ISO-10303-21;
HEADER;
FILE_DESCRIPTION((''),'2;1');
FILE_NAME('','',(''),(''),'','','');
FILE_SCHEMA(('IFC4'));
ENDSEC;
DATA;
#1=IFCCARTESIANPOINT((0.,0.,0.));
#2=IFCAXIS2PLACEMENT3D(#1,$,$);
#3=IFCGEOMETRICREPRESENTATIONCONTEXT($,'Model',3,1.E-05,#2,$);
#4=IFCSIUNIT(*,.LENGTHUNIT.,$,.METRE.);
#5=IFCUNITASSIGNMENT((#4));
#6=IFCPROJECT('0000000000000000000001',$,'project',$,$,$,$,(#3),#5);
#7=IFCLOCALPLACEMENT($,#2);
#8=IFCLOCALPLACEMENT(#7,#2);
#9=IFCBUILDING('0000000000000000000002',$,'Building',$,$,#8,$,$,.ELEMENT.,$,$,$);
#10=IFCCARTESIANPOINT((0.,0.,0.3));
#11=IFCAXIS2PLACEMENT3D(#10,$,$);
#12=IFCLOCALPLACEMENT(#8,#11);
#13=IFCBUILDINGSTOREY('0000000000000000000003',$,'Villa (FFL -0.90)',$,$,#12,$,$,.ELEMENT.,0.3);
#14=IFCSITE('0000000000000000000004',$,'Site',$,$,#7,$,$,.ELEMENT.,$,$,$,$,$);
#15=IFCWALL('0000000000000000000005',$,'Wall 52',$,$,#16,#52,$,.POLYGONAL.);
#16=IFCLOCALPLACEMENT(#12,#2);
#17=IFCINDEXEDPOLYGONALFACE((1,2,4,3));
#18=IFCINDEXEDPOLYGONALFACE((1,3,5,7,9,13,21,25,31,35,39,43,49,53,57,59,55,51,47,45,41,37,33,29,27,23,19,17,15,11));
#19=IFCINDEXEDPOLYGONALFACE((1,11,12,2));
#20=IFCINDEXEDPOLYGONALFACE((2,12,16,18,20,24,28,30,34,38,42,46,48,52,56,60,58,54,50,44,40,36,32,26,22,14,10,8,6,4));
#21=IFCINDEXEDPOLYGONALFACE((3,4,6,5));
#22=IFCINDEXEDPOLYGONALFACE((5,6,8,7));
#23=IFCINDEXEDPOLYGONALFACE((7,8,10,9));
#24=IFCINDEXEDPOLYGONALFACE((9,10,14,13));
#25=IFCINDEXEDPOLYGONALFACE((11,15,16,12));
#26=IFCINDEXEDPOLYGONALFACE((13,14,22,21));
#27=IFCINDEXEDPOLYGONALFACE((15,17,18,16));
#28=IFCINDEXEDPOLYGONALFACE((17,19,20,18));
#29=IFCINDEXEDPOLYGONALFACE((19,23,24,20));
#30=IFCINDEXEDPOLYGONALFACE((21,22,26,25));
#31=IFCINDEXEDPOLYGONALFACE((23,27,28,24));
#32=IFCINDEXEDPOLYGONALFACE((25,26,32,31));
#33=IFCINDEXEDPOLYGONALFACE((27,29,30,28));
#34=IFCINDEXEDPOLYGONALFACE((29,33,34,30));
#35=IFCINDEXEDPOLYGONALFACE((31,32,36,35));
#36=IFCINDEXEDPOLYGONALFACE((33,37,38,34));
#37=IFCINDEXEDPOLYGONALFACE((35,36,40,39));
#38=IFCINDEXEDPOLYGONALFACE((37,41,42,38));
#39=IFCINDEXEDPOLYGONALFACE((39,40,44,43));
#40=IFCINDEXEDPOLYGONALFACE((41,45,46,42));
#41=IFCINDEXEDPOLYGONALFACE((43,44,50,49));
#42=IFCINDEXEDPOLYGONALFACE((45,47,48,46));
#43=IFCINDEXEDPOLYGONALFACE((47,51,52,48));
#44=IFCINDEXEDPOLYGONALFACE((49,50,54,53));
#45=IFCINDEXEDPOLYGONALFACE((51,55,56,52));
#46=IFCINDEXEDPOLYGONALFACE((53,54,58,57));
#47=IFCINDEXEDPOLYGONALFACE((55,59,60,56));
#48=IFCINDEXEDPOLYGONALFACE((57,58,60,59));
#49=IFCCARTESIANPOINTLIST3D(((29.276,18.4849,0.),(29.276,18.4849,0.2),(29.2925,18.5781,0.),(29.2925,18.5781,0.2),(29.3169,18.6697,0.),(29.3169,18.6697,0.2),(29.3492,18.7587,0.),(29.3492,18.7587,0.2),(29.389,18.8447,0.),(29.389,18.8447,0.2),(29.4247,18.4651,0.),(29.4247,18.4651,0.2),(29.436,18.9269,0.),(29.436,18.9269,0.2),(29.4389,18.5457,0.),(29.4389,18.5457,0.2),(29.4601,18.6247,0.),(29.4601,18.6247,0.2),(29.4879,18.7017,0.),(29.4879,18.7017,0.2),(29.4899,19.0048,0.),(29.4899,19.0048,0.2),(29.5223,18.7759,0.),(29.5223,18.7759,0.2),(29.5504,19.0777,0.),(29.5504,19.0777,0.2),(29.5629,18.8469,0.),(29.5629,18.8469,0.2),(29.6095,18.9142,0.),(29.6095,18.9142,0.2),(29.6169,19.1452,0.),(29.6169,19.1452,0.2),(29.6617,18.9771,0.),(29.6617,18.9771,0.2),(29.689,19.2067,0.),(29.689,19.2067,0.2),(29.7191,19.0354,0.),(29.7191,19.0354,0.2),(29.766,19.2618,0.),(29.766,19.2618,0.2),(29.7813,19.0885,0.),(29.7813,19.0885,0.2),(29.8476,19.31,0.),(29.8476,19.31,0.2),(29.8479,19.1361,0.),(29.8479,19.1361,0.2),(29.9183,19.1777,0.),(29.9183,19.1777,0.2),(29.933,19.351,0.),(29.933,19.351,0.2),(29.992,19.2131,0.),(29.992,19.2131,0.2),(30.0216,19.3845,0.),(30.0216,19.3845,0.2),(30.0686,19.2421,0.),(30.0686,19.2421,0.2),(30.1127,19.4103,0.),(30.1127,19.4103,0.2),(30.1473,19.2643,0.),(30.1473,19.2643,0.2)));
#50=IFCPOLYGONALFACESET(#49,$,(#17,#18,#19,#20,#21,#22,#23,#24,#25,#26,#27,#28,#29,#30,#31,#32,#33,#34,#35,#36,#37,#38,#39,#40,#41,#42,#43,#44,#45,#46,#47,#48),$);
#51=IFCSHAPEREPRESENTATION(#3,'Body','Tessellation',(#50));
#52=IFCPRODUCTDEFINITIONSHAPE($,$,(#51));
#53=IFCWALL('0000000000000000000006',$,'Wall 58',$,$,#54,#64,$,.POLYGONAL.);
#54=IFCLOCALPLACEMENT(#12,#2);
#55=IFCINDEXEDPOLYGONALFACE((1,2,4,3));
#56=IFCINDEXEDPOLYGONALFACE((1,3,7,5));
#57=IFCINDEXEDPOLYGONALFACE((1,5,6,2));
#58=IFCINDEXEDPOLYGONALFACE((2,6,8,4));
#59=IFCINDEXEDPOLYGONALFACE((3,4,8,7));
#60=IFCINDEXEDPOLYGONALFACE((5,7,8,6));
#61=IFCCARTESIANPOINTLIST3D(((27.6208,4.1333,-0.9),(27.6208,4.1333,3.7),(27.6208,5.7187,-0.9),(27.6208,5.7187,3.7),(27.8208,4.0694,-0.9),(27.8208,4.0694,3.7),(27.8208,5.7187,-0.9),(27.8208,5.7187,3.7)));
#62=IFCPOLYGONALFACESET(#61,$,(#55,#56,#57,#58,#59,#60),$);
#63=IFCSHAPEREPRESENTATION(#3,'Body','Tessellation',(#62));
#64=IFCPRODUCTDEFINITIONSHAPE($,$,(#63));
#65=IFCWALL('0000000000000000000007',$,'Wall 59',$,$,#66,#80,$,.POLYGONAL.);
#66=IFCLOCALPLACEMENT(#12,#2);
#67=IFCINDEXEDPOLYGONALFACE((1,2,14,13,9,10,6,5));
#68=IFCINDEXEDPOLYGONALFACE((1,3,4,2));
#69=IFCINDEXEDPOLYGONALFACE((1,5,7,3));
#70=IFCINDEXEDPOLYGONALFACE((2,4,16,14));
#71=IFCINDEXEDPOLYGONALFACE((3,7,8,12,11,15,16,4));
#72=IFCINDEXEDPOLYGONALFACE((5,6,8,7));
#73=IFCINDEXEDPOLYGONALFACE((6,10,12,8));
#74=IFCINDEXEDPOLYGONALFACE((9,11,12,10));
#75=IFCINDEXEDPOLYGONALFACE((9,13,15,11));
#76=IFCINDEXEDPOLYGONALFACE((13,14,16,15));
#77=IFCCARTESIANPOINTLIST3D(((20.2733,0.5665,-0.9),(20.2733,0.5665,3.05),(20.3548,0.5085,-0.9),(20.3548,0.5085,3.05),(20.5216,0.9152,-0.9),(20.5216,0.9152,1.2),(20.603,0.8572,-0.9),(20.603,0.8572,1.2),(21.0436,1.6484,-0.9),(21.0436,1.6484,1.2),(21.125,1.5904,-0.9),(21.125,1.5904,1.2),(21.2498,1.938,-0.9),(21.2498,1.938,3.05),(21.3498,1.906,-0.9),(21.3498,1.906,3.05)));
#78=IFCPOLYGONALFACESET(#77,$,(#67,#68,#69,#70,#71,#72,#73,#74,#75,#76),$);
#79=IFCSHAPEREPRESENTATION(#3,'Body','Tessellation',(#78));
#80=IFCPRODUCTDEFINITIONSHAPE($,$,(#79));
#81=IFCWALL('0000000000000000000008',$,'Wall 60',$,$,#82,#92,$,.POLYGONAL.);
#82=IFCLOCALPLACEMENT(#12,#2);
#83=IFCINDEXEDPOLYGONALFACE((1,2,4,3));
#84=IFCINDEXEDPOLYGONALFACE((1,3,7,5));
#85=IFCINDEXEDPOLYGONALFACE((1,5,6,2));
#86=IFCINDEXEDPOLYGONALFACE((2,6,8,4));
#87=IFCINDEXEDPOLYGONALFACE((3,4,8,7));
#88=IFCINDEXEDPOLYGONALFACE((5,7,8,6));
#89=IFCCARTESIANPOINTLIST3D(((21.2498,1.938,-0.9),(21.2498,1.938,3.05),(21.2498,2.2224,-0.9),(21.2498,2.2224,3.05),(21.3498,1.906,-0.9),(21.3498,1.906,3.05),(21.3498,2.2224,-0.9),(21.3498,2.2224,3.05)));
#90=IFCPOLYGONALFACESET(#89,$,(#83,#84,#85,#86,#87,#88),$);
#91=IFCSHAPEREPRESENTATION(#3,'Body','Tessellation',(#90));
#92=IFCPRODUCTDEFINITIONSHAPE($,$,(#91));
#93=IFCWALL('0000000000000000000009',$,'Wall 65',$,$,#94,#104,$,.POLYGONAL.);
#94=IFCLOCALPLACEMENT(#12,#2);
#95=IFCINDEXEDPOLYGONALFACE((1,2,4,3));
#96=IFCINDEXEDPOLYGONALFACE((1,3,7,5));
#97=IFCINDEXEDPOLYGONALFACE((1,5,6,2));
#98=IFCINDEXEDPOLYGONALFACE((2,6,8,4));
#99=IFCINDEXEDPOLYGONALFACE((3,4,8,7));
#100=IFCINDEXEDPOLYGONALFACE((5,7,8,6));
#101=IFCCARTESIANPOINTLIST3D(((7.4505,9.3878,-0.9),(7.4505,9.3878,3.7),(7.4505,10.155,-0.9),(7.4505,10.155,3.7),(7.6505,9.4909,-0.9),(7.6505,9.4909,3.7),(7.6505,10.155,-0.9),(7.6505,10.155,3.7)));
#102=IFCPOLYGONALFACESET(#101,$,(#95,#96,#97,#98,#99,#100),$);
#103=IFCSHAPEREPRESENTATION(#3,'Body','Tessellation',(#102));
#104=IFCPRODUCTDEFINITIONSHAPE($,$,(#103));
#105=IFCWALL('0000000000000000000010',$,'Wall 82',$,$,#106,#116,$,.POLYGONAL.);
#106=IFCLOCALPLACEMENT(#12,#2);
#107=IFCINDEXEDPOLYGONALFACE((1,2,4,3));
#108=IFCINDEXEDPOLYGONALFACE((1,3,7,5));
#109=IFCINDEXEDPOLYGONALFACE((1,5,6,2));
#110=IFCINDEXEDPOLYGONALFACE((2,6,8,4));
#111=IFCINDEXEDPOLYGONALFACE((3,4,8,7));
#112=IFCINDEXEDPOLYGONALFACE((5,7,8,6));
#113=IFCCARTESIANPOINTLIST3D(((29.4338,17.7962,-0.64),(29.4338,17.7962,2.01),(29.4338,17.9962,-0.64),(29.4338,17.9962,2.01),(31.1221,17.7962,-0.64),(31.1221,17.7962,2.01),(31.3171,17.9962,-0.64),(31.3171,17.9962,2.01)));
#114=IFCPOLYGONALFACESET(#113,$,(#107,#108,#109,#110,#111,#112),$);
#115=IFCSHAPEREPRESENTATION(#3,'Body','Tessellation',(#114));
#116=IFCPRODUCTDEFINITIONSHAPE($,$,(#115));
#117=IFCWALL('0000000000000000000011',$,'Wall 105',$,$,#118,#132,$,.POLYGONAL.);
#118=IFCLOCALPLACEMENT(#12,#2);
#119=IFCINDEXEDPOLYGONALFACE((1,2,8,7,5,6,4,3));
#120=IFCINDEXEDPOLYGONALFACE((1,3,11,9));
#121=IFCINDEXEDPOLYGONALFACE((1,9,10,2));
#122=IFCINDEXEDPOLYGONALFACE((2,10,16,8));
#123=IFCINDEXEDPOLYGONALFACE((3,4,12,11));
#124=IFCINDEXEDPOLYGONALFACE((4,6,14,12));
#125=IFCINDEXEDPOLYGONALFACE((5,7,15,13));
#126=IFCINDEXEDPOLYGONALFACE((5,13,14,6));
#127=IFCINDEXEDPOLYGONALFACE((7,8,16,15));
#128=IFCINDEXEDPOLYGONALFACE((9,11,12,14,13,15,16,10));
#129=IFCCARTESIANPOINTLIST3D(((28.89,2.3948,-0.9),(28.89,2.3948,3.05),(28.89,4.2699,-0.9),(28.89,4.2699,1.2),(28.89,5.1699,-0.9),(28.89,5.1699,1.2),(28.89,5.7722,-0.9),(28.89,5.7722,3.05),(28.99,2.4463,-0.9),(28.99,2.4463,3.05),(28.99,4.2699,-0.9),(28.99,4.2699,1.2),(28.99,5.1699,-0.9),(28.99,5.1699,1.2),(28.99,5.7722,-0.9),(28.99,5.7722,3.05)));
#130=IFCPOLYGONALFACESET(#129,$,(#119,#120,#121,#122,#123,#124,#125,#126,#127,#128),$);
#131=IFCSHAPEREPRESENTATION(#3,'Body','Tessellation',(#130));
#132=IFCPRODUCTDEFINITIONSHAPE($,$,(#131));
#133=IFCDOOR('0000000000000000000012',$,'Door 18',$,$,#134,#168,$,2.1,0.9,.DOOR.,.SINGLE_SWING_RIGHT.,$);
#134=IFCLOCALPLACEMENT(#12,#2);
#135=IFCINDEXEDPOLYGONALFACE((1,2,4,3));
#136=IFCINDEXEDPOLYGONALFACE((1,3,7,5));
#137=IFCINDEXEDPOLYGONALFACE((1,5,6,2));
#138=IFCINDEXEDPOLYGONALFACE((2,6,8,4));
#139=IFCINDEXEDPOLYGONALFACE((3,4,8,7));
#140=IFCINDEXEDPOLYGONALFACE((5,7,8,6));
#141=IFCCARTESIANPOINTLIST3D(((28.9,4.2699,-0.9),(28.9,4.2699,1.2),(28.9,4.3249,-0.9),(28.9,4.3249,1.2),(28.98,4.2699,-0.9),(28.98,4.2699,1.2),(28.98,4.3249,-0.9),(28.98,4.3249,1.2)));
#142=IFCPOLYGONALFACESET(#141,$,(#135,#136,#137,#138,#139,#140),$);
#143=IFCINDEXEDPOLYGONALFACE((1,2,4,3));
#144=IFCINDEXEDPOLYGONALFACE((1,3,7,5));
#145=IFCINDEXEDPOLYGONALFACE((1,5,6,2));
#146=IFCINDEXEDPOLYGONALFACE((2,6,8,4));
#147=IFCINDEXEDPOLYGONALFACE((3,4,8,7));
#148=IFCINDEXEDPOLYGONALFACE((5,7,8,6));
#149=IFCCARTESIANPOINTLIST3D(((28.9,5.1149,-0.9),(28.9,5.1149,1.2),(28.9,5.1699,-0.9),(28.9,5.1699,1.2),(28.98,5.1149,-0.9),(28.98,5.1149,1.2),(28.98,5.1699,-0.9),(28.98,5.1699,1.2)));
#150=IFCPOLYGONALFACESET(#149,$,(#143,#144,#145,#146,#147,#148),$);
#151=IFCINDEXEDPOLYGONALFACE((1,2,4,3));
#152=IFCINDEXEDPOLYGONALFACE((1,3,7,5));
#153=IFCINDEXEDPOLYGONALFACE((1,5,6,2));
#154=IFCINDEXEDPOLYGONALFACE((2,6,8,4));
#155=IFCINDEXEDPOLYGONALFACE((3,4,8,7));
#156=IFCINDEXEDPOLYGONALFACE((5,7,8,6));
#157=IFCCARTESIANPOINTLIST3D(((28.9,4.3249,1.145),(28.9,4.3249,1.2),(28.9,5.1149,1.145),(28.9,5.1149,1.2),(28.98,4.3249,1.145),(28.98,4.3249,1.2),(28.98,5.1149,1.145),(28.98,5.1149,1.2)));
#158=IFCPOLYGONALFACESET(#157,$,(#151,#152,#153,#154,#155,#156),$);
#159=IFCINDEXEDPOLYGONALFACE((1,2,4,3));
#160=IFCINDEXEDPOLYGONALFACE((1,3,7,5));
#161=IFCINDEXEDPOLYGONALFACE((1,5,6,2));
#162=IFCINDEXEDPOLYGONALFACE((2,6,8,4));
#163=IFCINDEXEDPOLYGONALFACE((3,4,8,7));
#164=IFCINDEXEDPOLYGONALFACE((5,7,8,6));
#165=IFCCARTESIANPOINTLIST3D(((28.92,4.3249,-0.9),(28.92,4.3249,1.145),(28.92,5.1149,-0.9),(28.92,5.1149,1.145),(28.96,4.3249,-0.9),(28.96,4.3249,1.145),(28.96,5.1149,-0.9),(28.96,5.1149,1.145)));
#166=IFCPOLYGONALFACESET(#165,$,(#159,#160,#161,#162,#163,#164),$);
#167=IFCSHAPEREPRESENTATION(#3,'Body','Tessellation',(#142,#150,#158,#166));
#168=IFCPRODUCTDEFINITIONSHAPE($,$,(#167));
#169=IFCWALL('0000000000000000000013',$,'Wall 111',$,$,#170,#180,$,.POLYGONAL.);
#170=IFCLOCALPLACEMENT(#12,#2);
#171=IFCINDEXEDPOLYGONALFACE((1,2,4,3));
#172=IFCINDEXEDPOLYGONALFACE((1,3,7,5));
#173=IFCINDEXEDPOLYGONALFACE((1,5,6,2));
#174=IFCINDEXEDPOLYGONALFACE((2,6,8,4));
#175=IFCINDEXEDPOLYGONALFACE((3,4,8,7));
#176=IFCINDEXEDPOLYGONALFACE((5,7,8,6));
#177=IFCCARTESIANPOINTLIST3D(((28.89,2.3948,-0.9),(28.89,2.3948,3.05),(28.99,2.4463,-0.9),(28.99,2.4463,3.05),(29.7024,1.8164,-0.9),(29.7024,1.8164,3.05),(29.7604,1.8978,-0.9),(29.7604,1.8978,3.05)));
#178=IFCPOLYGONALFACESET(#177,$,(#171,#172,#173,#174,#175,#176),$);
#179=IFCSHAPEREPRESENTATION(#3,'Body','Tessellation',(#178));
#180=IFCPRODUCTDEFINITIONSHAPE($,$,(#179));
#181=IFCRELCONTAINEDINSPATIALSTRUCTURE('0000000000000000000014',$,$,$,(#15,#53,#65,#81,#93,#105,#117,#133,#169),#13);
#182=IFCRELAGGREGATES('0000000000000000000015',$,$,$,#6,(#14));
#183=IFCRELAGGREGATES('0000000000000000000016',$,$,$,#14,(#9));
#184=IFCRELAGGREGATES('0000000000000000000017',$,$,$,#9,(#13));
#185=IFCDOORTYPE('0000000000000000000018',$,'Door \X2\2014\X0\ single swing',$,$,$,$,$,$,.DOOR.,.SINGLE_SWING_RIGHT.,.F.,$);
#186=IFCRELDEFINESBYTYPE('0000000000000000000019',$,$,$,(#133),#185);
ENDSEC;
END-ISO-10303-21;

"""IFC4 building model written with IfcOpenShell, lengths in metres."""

from ifc_helpers import new_model, si_unit, frame, frame_2d, origin, origin_with_axes, place, context, project, spatial, polyline, rectangle, outline, extrude, type_object, element, fill, save


model = new_model("IFC4")

# Units and contexts
model_context = context("Model", 3, precision=1e-05, world=origin())
ifc_project = project(units=[si_unit("LENGTHUNIT", "METRE")], contexts=[model_context])

# Site, building, storey
site_placement = place(None, origin())
site = spatial("IfcSite", under=ifc_project, at=site_placement, Name="Site", CompositionType="ELEMENT")
building_placement = place(site_placement, origin())
building = spatial("IfcBuilding", under=site, at=building_placement, Name="Building", CompositionType="ELEMENT")
storey_placement = place(building_placement, frame((0.0, 0.0, 0.3)))
storey = spatial("IfcBuildingStorey", under=building, at=storey_placement, Name="Villa (FFL -0.90)", CompositionType="ELEMENT", Elevation=0.3)

# Walls
wall_1_placement = place(storey_placement, origin_with_axes())
element("IfcWall", 1, at=wall_1_placement, inside=storey, Name="Wall 52", PredefinedType="POLYGONAL", context=model_context, shape_type="SweptSolid", body=[
    extrude(outline(polyline([(29.276, 18.4849), (29.2925, 18.5781), (29.3169, 18.6697), (29.3492, 18.7587), (29.389, 18.8447), (29.436, 18.9269), (29.4899, 19.0048), (29.5504, 19.0777), (29.6169, 19.1452), (29.689, 19.2067), (29.766, 19.2618), (29.8476, 19.31), (29.933, 19.351), (30.0216, 19.3845), (30.1127, 19.4103), (30.1473, 19.2643), (30.0685, 19.2421), (29.992, 19.2131), (29.9183, 19.1777), (29.8479, 19.1361), (29.7813, 19.0885), (29.7191, 19.0354), (29.6617, 18.9771), (29.6095, 18.9142), (29.5629, 18.8469), (29.5223, 18.7759), (29.4879, 18.7017), (29.4601, 18.6247), (29.4389, 18.5457), (29.4247, 18.4651), (29.276, 18.4849)])), origin(), (0.0, 0.0, 1.0), 0.2),
])
wall_2_placement = place(storey_placement, frame((0.0, 0.0, -0.9), z_axis=(0.0, 0.0, 1.0), x_axis=(1.0, 0.0, 0.0)))
element("IfcWall", 2, at=wall_2_placement, inside=storey, Name="Wall 58", PredefinedType="POLYGONAL", context=model_context, shape_type="SweptSolid", body=[
    extrude(outline(polyline([(27.6208, 4.1333), (27.8208, 4.0694), (27.8208, 5.7187), (27.6208, 5.7187), (27.6208, 4.1333)])), origin(), (0.0, 0.0, 1.0), 4.6),
])

# Wall, opening
wall_3_placement = place(storey_placement, frame((0.0, 0.0, -0.9), z_axis=(0.0, 0.0, 1.0), x_axis=(1.0, 0.0, 0.0)))
wall_3 = element("IfcWall", 3, at=wall_3_placement, inside=storey, Name="Wall 59", PredefinedType="POLYGONAL", context=model_context, shape_type="SweptSolid", body=[
    extrude(outline(polyline([(21.3498, 1.906), (21.2498, 1.938), (20.2733, 0.5665), (20.3548, 0.5085), (21.3498, 1.906)])), origin(), (0.0, 0.0, 1.0), 3.95),
])
opening_1_placement = place(storey_placement, frame((21.0843, 1.6194, -0.9), z_axis=(0.0, 0.0, 1.0), x_axis=(-0.579992, -0.814622, 0.0)))
element("IfcOpeningElement", 4, at=opening_1_placement, cuts=wall_3, PredefinedType="OPENING", context=model_context, shape_type="SweptSolid", body=[
    extrude(rectangle(XDim=0.9, YDim=0.16, at=frame_2d((0.45, 0.0))), origin(), (0.0, 0.0, 1.0), 2.1),
])

# Walls
wall_4_placement = place(storey_placement, frame((0.0, 0.0, -0.9), z_axis=(0.0, 0.0, 1.0), x_axis=(1.0, 0.0, 0.0)))
element("IfcWall", 5, at=wall_4_placement, inside=storey, Name="Wall 60", PredefinedType="POLYGONAL", context=model_context, shape_type="SweptSolid", body=[
    extrude(outline(polyline([(21.3498, 2.2224), (21.2498, 2.2224), (21.2498, 1.938), (21.3498, 1.906), (21.3498, 2.2224)])), origin(), (0.0, 0.0, 1.0), 3.95),
])
wall_5_placement = place(storey_placement, frame((0.0, 0.0, -0.9), z_axis=(0.0, 0.0, 1.0), x_axis=(1.0, 0.0, 0.0)))
element("IfcWall", 6, at=wall_5_placement, inside=storey, Name="Wall 65", PredefinedType="POLYGONAL", context=model_context, shape_type="SweptSolid", body=[
    extrude(outline(polyline([(7.6505, 10.155), (7.4505, 10.155), (7.4505, 9.3878), (7.6505, 9.4909), (7.6505, 10.155)])), origin(), (0.0, 0.0, 1.0), 4.6),
])
wall_6_placement = place(storey_placement, frame((0.0, 0.0, -0.64), z_axis=(0.0, 0.0, 1.0), x_axis=(1.0, 0.0, 0.0)))
element("IfcWall", 7, at=wall_6_placement, inside=storey, Name="Wall 82", PredefinedType="POLYGONAL", context=model_context, shape_type="SweptSolid", body=[
    extrude(outline(polyline([(31.1221, 17.7962), (31.3171, 17.9962), (29.4338, 17.9962), (29.4338, 17.7962), (31.1221, 17.7962)])), origin(), (0.0, 0.0, 1.0), 2.65),
])

# Wall, opening, door
wall_7_placement = place(storey_placement, frame((0.0, 0.0, -0.9), z_axis=(0.0, 0.0, 1.0), x_axis=(1.0, 0.0, 0.0)))
wall_7 = element("IfcWall", 8, at=wall_7_placement, inside=storey, Name="Wall 105", PredefinedType="POLYGONAL", context=model_context, shape_type="SweptSolid", body=[
    extrude(outline(polyline([(28.89, 2.3948), (28.99, 2.4463), (28.99, 5.7721), (28.89, 5.7721), (28.89, 2.3948)])), origin(), (0.0, 0.0, 1.0), 3.95),
])
opening_2_placement = place(storey_placement, frame((28.94, 4.2699, -0.9), z_axis=(0.0, 0.0, 1.0), x_axis=(0.0, 1.0, 0.0)))
opening_2 = element("IfcOpeningElement", 9, at=opening_2_placement, cuts=wall_7, PredefinedType="OPENING", context=model_context, shape_type="SweptSolid", body=[
    extrude(rectangle(XDim=0.9, YDim=0.16, at=frame_2d((0.45, 0.0))), origin(), (0.0, 0.0, 1.0), 2.1),
])
door_type = type_object("IfcDoorType", Name="Door — single swing", OperationType="SINGLE_SWING_RIGHT", ParameterTakesPrecedence=False, PredefinedType="DOOR")
door_placement = place(storey_placement, frame((28.94, 4.2699, -0.9), z_axis=(0.0, 0.0, 1.0), x_axis=(0.0, 1.0, 0.0)))
door = element("IfcDoor", 10, at=door_placement, inside=storey, type_object=door_type, Name="Door 18", OperationType="SINGLE_SWING_RIGHT", OverallHeight=2.1, OverallWidth=0.9, PredefinedType="DOOR", context=model_context, shape_type="SweptSolid", body=[
    extrude(rectangle(XDim=0.055, YDim=0.08, at=frame_2d((0.0275, 0.0))), origin(), (0.0, 0.0, 1.0), 2.1),
    extrude(rectangle(XDim=0.055, YDim=0.08, at=frame_2d((0.8725, 0.0))), origin(), (0.0, 0.0, 1.0), 2.1),
    extrude(rectangle(XDim=0.79, YDim=0.08, at=frame_2d((0.45, 0.0))), frame((0.0, 0.0, 2.045)), (0.0, 0.0, 1.0), 0.055),
    extrude(rectangle(XDim=0.79, YDim=0.04, at=frame_2d((0.45, 0.0))), origin(), (0.0, 0.0, 1.0), 2.045),
])
fill(opening_2, door)

# Wall
wall_8_placement = place(storey_placement, frame((0.0, 0.0, -0.9), z_axis=(0.0, 0.0, 1.0), x_axis=(1.0, 0.0, 0.0)))
element("IfcWall", 11, at=wall_8_placement, inside=storey, Name="Wall 111", PredefinedType="POLYGONAL", context=model_context, shape_type="SweptSolid", body=[
    extrude(outline(polyline([(29.7024, 1.8164), (29.7604, 1.8978), (28.99, 2.4463), (28.89, 2.3948), (29.7024, 1.8164)])), origin(), (0.0, 0.0, 1.0), 3.95),
])

save(model, "model.ifc")
